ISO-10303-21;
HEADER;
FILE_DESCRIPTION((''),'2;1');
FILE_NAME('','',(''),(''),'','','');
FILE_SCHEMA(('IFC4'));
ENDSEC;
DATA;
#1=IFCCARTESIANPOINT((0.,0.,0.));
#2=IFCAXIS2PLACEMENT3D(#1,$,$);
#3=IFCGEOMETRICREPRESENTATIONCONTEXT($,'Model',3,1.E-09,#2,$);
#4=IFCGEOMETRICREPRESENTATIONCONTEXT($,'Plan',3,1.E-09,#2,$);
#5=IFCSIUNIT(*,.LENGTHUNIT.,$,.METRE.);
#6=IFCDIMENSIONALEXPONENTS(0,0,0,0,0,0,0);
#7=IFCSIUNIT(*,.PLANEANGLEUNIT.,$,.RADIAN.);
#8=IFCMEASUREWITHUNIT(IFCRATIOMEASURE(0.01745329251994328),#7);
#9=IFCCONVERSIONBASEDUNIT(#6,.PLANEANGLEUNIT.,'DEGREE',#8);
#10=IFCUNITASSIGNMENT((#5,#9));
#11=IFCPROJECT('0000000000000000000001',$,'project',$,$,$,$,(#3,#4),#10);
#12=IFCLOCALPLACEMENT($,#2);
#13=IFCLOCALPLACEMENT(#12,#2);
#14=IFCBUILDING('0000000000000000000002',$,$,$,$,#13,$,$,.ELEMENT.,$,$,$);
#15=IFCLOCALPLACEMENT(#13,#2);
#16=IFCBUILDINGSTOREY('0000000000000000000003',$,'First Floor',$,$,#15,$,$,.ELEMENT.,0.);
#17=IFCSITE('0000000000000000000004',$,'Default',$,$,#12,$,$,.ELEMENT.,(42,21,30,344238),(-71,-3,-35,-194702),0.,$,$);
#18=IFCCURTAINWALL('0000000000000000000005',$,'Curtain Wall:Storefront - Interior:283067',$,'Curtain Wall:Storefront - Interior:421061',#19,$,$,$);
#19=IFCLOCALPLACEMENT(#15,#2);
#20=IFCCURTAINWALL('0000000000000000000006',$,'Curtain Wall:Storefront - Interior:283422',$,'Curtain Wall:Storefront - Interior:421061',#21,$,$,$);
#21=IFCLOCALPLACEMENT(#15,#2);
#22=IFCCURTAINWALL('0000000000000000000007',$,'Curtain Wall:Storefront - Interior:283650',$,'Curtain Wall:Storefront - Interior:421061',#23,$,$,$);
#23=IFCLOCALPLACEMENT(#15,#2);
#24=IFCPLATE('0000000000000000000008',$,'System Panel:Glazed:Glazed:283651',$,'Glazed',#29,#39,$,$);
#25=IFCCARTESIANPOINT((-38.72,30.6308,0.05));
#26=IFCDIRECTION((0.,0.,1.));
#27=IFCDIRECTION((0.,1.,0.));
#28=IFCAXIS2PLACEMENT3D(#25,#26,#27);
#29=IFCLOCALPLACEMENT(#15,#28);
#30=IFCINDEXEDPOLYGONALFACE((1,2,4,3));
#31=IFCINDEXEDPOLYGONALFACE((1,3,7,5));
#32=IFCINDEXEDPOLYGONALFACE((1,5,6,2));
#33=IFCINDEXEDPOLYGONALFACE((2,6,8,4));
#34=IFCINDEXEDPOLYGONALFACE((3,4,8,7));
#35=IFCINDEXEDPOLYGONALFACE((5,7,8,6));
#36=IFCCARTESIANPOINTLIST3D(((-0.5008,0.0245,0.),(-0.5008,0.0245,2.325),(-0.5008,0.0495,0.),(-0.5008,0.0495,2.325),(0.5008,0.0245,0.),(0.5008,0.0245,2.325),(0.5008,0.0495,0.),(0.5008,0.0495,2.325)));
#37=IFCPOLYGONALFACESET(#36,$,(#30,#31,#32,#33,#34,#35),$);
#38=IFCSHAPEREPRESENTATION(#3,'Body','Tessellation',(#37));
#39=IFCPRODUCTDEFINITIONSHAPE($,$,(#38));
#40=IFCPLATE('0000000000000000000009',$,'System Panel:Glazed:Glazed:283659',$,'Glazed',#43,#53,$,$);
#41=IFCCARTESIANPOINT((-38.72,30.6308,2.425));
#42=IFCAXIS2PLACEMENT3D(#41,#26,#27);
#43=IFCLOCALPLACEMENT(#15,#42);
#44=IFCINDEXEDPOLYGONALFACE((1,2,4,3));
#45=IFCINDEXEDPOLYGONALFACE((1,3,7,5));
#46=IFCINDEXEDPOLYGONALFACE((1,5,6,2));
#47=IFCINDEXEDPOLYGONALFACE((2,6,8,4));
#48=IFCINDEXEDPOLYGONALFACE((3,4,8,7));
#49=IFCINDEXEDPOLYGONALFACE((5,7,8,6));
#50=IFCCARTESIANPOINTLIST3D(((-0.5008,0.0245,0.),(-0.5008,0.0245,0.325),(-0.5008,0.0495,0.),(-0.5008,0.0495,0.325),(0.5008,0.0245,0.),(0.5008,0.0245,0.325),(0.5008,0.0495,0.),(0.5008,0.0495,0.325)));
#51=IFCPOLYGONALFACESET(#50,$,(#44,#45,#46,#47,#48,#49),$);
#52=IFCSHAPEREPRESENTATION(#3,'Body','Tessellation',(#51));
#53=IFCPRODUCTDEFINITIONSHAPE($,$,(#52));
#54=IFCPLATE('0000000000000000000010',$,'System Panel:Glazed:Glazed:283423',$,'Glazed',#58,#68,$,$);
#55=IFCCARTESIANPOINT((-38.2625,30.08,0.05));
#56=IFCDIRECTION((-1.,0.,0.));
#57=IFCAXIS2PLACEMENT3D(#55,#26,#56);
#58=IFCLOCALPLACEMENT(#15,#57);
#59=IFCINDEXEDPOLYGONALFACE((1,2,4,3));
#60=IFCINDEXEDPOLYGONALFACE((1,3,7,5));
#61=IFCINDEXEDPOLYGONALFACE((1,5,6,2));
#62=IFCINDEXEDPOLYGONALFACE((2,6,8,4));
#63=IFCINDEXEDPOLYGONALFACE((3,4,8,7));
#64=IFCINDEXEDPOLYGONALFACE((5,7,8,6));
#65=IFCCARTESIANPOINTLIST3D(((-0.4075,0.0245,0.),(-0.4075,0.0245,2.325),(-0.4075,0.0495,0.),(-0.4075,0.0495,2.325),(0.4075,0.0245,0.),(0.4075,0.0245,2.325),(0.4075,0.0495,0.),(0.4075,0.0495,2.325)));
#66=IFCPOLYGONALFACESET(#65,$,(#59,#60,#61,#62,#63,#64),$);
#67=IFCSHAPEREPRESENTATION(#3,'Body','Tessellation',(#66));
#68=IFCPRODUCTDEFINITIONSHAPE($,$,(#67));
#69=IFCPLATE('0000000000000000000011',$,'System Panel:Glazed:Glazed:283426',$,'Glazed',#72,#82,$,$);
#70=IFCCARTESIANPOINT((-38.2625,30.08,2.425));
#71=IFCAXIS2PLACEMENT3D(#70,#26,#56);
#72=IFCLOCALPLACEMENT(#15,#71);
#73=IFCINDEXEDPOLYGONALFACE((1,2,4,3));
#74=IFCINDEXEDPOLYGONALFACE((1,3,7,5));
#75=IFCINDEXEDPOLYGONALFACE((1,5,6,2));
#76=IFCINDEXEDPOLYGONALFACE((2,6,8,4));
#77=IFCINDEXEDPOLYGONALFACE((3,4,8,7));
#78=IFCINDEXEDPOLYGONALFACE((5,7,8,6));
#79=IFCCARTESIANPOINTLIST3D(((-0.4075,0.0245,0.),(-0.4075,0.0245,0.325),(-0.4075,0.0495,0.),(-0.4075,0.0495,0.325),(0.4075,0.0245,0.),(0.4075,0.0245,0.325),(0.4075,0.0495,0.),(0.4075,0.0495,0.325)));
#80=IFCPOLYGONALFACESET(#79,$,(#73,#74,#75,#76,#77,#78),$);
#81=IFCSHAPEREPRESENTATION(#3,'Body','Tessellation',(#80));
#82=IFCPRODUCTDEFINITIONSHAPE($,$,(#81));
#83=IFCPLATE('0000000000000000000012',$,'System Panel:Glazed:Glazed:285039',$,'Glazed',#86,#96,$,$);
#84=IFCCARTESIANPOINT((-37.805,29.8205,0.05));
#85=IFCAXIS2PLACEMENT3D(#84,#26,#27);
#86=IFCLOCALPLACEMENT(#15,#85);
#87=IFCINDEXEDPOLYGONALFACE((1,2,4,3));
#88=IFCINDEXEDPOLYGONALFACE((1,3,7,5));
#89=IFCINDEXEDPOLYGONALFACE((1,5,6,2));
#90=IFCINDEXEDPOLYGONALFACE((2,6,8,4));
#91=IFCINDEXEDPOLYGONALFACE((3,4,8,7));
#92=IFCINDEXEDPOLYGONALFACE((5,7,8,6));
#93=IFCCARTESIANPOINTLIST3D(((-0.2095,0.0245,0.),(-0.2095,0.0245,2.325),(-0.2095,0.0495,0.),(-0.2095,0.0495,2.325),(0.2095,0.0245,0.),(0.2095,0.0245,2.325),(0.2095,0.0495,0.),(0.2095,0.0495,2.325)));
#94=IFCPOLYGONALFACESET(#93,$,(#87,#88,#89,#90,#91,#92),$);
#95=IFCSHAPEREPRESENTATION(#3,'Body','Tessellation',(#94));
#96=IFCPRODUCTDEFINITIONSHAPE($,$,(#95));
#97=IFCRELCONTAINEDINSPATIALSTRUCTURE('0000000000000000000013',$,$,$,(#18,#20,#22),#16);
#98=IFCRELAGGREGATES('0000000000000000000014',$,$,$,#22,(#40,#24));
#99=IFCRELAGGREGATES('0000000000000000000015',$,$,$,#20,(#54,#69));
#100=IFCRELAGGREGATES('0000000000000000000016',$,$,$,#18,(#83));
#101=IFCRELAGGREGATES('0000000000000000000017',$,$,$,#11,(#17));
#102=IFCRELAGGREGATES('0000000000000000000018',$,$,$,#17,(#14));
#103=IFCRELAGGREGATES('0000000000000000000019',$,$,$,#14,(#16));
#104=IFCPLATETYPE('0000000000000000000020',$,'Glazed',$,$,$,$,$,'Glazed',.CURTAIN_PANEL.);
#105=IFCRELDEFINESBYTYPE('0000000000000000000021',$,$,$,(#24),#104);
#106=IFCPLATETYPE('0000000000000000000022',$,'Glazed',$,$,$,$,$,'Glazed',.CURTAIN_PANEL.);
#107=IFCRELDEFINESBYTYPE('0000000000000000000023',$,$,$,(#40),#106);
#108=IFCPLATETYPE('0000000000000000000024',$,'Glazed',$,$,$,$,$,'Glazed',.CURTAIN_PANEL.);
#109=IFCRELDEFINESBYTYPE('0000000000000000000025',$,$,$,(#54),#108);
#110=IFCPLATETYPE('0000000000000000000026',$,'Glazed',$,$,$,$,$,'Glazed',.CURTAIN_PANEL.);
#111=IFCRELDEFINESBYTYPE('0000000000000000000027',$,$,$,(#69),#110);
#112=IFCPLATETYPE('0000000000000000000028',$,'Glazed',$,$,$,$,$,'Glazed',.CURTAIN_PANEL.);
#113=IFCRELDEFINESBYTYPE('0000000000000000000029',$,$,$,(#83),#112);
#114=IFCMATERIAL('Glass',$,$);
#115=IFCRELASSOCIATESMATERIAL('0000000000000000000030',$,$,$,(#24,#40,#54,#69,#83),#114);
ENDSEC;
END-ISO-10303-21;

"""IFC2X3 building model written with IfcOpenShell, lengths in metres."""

from ifc_helpers import new_model, entity, si_unit, converted_unit, frame, origin, origin_2d_with_axis, place, context, project, spatial, rectangle, extrude, source, transform, mapped, material, type_object, type_shapes, element, aggregate, save


model = new_model("IFC2X3")

# Units and contexts
model_context = context("Model", 3, precision=1e-09, world=origin())
plan_context = context("Plan", 3, precision=1e-09, world=origin())
ifc_project = project(units=[si_unit("LENGTHUNIT", "METRE"), converted_unit("PLANEANGLEUNIT", "DEGREE", entity("IfcRatioMeasure", 0.01745329251994328), si_unit("PLANEANGLEUNIT", "RADIAN"), dimensions=[0, 0, 0, 0, 0, 0, 0])], contexts=[model_context, plan_context])

# Site, building, storey
site_placement = place(None, origin())
site = spatial("IfcSite", under=ifc_project, at=site_placement, Name="Default", CompositionType="ELEMENT", RefLatitude=(42, 21, 30, 344238), RefLongitude=(-71, -3, -35, -194702), RefElevation=0.0)
building_placement = place(site_placement, origin())
building = spatial("IfcBuilding", under=site, at=building_placement, CompositionType="ELEMENT")
storey_placement = place(building_placement, origin())
storey = spatial("IfcBuildingStorey", under=building, at=storey_placement, Name="First Floor", CompositionType="ELEMENT", Elevation=0.0)

# Curtain walls
curtain_wall_1_placement = place(storey_placement, origin())
curtain_wall_1 = element("IfcCurtainWall", 1, at=curtain_wall_1_placement, inside=storey, Name="Curtain Wall:Storefront - Interior:283067", ObjectType="Curtain Wall:Storefront - Interior:421061")
curtain_wall_2_placement = place(storey_placement, origin())
curtain_wall_2 = element("IfcCurtainWall", 2, at=curtain_wall_2_placement, inside=storey, Name="Curtain Wall:Storefront - Interior:283422", ObjectType="Curtain Wall:Storefront - Interior:421061")

# Curtain wall, plates
curtain_wall_3_placement = place(storey_placement, origin())
curtain_wall_3 = element("IfcCurtainWall", 3, at=curtain_wall_3_placement, inside=storey, Name="Curtain Wall:Storefront - Interior:283650", ObjectType="Curtain Wall:Storefront - Interior:421061")
ifc_material_1 = material(Name="Glass")
plate_type_1 = type_object("IfcPlateType", Name="Glazed", ElementType="Glazed", PredefinedType="CURTAIN_PANEL")
shared_shape_1 = source(origin(), model_context, "Body", "SweptSolid", [
    extrude(rectangle(XDim=0.025, YDim=1.0017, at=origin_2d_with_axis()), frame((0.0, 0.037, 0.0), z_axis=(0.0, 0.0, 1.0), x_axis=(0.0, 1.0, 0.0)), (0.0, 0.0, 1.0), 2.325),
])
type_shapes(plate_type_1, [shared_shape_1])
plate_1_placement = place(storey_placement, frame((-38.72, 30.6308, 0.05), z_axis=(0.0, 0.0, 1.0), x_axis=(0.0, 1.0, 0.0)))
plate_1 = element("IfcPlate", 4, at=plate_1_placement, type_object=plate_type_1, material=ifc_material_1, Name="System Panel:Glazed:Glazed:283651", ObjectType="Glazed", context=model_context, shape_type="MappedRepresentation", body=[
    mapped(shared_shape_1, transform((0.0, 0.0, 0.0), scale=1.0)),
])
plate_type_2 = type_object("IfcPlateType", Name="Glazed", ElementType="Glazed", PredefinedType="CURTAIN_PANEL")
shared_shape_2 = source(origin(), model_context, "Body", "SweptSolid", [
    extrude(rectangle(XDim=0.025, YDim=1.0017, at=origin_2d_with_axis()), frame((0.0, 0.037, 0.0), z_axis=(0.0, 0.0, 1.0), x_axis=(0.0, 1.0, 0.0)), (0.0, 0.0, 1.0), 0.325),
])
type_shapes(plate_type_2, [shared_shape_2])
plate_2_placement = place(storey_placement, frame((-38.72, 30.6308, 2.425), z_axis=(0.0, 0.0, 1.0), x_axis=(0.0, 1.0, 0.0)))
plate_2 = element("IfcPlate", 5, at=plate_2_placement, type_object=plate_type_2, material=ifc_material_1, Name="System Panel:Glazed:Glazed:283659", ObjectType="Glazed", context=model_context, shape_type="MappedRepresentation", body=[
    mapped(shared_shape_2, transform((0.0, 0.0, 0.0), scale=1.0)),
])
aggregate(curtain_wall_3, [plate_2, plate_1])

# Plates
plate_type_3 = type_object("IfcPlateType", Name="Glazed", ElementType="Glazed", PredefinedType="CURTAIN_PANEL")
shared_shape_3 = source(origin(), model_context, "Body", "SweptSolid", [
    extrude(rectangle(XDim=0.025, YDim=0.815, at=origin_2d_with_axis()), frame((0.0, 0.037, 0.0), z_axis=(0.0, 0.0, 1.0), x_axis=(0.0, 1.0, 0.0)), (0.0, 0.0, 1.0), 2.325),
])
type_shapes(plate_type_3, [shared_shape_3])
plate_3_placement = place(storey_placement, frame((-38.2625, 30.08, 0.05), z_axis=(0.0, 0.0, 1.0), x_axis=(-1.0, 0.0, 0.0)))
plate_3 = element("IfcPlate", 6, at=plate_3_placement, type_object=plate_type_3, material=ifc_material_1, Name="System Panel:Glazed:Glazed:283423", ObjectType="Glazed", context=model_context, shape_type="MappedRepresentation", body=[
    mapped(shared_shape_3, transform((0.0, 0.0, 0.0), scale=1.0)),
])
plate_type_4 = type_object("IfcPlateType", Name="Glazed", ElementType="Glazed", PredefinedType="CURTAIN_PANEL")
shared_shape_4 = source(origin(), model_context, "Body", "SweptSolid", [
    extrude(rectangle(XDim=0.025, YDim=0.815, at=origin_2d_with_axis()), frame((0.0, 0.037, 0.0), z_axis=(0.0, 0.0, 1.0), x_axis=(0.0, 1.0, 0.0)), (0.0, 0.0, 1.0), 0.325),
])
type_shapes(plate_type_4, [shared_shape_4])
plate_4_placement = place(storey_placement, frame((-38.2625, 30.08, 2.425), z_axis=(0.0, 0.0, 1.0), x_axis=(-1.0, 0.0, 0.0)))
plate_4 = element("IfcPlate", 7, at=plate_4_placement, type_object=plate_type_4, material=ifc_material_1, Name="System Panel:Glazed:Glazed:283426", ObjectType="Glazed", context=model_context, shape_type="MappedRepresentation", body=[
    mapped(shared_shape_4, transform((0.0, 0.0, 0.0), scale=1.0)),
])
aggregate(curtain_wall_2, [plate_3, plate_4])
plate_type_5 = type_object("IfcPlateType", Name="Glazed", ElementType="Glazed", PredefinedType="CURTAIN_PANEL")
shared_shape_5 = source(origin(), model_context, "Body", "SweptSolid", [
    extrude(rectangle(XDim=0.025, YDim=0.419, at=origin_2d_with_axis()), frame((0.0, 0.037, 0.0), z_axis=(0.0, 0.0, 1.0), x_axis=(0.0, 1.0, 0.0)), (0.0, 0.0, 1.0), 2.325),
])
type_shapes(plate_type_5, [shared_shape_5])
plate_5_placement = place(storey_placement, frame((-37.805, 29.8205, 0.05), z_axis=(0.0, 0.0, 1.0), x_axis=(0.0, 1.0, 0.0)))
plate_5 = element("IfcPlate", 8, at=plate_5_placement, type_object=plate_type_5, material=ifc_material_1, Name="System Panel:Glazed:Glazed:285039", ObjectType="Glazed", context=model_context, shape_type="MappedRepresentation", body=[
    mapped(shared_shape_5, transform((0.0, 0.0, 0.0), scale=1.0)),
])

aggregate(curtain_wall_1, [plate_5])

save(model, "model.ifc")
